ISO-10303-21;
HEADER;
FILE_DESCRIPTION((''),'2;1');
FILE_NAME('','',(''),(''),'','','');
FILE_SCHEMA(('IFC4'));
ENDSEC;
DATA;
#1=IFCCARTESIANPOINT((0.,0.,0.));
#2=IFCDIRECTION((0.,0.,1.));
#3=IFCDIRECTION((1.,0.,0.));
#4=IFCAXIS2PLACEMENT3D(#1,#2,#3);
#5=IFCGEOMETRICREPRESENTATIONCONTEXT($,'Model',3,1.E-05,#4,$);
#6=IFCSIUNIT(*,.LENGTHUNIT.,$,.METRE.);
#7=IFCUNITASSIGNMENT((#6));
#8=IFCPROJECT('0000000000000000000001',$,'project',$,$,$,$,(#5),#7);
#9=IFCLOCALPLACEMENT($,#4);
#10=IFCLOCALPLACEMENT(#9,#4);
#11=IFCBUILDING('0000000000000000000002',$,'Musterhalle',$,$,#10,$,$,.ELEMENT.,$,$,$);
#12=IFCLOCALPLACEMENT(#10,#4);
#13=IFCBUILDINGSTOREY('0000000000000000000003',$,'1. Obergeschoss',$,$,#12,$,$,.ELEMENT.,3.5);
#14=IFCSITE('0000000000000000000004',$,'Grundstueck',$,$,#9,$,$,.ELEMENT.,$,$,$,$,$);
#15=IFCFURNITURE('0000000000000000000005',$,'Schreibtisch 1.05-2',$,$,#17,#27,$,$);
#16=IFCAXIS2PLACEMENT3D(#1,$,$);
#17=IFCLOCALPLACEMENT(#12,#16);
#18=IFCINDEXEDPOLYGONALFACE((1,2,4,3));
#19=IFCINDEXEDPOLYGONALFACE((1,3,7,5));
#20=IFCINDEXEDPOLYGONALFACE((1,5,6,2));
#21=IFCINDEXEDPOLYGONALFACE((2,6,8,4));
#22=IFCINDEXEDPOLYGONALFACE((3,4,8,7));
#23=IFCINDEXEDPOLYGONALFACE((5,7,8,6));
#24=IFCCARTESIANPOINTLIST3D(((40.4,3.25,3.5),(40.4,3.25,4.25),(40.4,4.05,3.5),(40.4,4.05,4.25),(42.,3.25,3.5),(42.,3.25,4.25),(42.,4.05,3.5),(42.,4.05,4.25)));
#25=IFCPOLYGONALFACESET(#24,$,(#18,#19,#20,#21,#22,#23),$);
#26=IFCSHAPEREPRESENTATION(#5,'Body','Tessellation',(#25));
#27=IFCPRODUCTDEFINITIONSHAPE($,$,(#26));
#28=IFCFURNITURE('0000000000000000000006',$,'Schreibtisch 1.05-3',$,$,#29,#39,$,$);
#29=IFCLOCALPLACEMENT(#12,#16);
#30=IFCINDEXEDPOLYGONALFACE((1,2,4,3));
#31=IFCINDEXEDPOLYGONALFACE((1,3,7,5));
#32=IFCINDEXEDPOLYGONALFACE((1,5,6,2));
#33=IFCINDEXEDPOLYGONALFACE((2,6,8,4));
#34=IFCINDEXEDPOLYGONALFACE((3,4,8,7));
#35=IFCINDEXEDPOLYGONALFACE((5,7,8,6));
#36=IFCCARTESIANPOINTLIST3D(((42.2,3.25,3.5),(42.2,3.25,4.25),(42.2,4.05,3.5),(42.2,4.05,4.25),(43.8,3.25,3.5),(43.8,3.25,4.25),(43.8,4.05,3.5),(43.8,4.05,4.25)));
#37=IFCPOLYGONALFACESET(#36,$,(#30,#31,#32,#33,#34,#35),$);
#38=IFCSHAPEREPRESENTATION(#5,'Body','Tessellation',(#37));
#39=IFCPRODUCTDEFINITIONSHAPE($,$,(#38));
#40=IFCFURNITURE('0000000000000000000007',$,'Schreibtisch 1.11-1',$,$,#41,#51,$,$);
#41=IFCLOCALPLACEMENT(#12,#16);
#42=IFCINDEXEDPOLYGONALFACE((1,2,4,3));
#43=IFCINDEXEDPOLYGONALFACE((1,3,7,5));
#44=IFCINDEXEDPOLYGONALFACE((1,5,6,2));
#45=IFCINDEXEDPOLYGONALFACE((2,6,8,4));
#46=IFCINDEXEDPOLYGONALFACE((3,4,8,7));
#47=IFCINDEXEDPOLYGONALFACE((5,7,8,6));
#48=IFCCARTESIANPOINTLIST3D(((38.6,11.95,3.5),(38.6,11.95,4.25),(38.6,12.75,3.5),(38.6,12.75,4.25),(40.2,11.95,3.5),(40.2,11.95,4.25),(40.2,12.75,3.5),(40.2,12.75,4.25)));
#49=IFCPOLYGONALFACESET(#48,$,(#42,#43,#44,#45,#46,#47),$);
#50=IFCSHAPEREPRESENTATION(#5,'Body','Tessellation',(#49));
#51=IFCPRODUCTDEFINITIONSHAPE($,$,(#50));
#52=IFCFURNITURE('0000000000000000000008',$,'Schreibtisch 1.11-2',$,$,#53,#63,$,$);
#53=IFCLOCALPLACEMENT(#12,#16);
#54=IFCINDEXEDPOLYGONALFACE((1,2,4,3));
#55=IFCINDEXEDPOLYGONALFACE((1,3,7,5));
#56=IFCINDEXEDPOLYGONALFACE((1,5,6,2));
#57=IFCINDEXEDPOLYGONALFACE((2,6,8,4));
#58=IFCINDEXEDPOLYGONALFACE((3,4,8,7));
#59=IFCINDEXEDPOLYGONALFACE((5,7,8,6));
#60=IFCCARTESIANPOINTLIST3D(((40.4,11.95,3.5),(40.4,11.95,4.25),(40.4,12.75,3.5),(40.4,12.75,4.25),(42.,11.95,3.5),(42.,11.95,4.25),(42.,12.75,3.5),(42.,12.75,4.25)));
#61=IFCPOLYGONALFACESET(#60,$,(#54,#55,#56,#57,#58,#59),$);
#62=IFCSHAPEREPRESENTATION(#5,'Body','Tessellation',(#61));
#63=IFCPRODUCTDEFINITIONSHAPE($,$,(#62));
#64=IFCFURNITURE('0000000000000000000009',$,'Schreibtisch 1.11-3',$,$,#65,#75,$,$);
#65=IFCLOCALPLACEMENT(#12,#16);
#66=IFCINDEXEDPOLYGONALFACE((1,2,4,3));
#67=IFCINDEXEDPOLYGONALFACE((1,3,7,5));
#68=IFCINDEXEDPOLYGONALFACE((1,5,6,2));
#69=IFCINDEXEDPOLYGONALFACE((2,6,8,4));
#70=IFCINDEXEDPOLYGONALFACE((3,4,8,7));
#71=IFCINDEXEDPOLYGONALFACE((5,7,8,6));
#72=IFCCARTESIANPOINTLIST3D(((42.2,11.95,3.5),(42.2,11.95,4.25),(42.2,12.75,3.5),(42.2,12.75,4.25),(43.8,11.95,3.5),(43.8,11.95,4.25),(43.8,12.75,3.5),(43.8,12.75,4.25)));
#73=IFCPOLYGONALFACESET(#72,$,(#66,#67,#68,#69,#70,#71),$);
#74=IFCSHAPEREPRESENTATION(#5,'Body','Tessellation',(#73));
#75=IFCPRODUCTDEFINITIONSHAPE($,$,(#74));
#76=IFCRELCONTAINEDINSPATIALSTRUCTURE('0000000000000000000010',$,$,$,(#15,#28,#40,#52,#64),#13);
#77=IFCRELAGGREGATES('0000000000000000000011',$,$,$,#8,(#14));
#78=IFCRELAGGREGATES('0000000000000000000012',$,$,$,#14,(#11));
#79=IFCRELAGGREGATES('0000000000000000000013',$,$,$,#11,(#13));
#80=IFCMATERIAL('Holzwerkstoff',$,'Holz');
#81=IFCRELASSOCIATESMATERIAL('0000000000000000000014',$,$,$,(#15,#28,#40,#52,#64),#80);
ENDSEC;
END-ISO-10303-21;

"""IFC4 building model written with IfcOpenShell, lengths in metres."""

from ifc_helpers import new_model, si_unit, frame, origin_with_axes, origin_2d, place, context, project, spatial, rectangle, extrude, material, element, save


model = new_model("IFC4")

# Units and contexts
model_context = context("Model", 3, precision=1e-05, world=origin_with_axes())
ifc_project = project(units=[si_unit("LENGTHUNIT", "METRE")], contexts=[model_context])

# Site, building, storey
site_placement = place(None, origin_with_axes())
site = spatial("IfcSite", under=ifc_project, at=site_placement, Name="Grundstueck", CompositionType="ELEMENT")
building_placement = place(site_placement, origin_with_axes())
building = spatial("IfcBuilding", under=site, at=building_placement, Name="Musterhalle", CompositionType="ELEMENT")
storey_placement = place(building_placement, origin_with_axes())
storey = spatial("IfcBuildingStorey", under=building, at=storey_placement, Name="1. Obergeschoss", CompositionType="ELEMENT", Elevation=3.5)

# Shared definitions
placement = place(storey_placement, origin_with_axes())

# Shared definitions
ifc_material_1 = material(Name="Holzwerkstoff", Category="Holz")

# Furniture
element("IfcFurniture", 1, at=placement, inside=storey, material=ifc_material_1, Name="Schreibtisch 1.05-2", context=model_context, shape_type="SweptSolid", body=[
    extrude(rectangle(XDim=1.6, YDim=0.8, at=origin_2d()), frame((41.2, 3.65, 3.5), z_axis=(0.0, 0.0, 1.0), x_axis=(1.0, 0.0, 0.0)), (0.0, 0.0, 1.0), 0.75),
])
element("IfcFurniture", 2, at=placement, inside=storey, material=ifc_material_1, Name="Schreibtisch 1.05-3", context=model_context, shape_type="SweptSolid", body=[
    extrude(rectangle(XDim=1.6, YDim=0.8, at=origin_2d()), frame((43.0, 3.65, 3.5), z_axis=(0.0, 0.0, 1.0), x_axis=(1.0, 0.0, 0.0)), (0.0, 0.0, 1.0), 0.75),
])
element("IfcFurniture", 3, at=placement, inside=storey, material=ifc_material_1, Name="Schreibtisch 1.11-1", context=model_context, shape_type="SweptSolid", body=[
    extrude(rectangle(XDim=1.6, YDim=0.8, at=origin_2d()), frame((39.4, 12.35, 3.5), z_axis=(0.0, 0.0, 1.0), x_axis=(1.0, 0.0, 0.0)), (0.0, 0.0, 1.0), 0.75),
])
element("IfcFurniture", 4, at=placement, inside=storey, material=ifc_material_1, Name="Schreibtisch 1.11-2", context=model_context, shape_type="SweptSolid", body=[
    extrude(rectangle(XDim=1.6, YDim=0.8, at=origin_2d()), frame((41.2, 12.35, 3.5), z_axis=(0.0, 0.0, 1.0), x_axis=(1.0, 0.0, 0.0)), (0.0, 0.0, 1.0), 0.75),
])
element("IfcFurniture", 5, at=placement, inside=storey, material=ifc_material_1, Name="Schreibtisch 1.11-3", context=model_context, shape_type="SweptSolid", body=[
    extrude(rectangle(XDim=1.6, YDim=0.8, at=origin_2d()), frame((43.0, 12.35, 3.5), z_axis=(0.0, 0.0, 1.0), x_axis=(1.0, 0.0, 0.0)), (0.0, 0.0, 1.0), 0.75),
])

save(model, "model.ifc")
